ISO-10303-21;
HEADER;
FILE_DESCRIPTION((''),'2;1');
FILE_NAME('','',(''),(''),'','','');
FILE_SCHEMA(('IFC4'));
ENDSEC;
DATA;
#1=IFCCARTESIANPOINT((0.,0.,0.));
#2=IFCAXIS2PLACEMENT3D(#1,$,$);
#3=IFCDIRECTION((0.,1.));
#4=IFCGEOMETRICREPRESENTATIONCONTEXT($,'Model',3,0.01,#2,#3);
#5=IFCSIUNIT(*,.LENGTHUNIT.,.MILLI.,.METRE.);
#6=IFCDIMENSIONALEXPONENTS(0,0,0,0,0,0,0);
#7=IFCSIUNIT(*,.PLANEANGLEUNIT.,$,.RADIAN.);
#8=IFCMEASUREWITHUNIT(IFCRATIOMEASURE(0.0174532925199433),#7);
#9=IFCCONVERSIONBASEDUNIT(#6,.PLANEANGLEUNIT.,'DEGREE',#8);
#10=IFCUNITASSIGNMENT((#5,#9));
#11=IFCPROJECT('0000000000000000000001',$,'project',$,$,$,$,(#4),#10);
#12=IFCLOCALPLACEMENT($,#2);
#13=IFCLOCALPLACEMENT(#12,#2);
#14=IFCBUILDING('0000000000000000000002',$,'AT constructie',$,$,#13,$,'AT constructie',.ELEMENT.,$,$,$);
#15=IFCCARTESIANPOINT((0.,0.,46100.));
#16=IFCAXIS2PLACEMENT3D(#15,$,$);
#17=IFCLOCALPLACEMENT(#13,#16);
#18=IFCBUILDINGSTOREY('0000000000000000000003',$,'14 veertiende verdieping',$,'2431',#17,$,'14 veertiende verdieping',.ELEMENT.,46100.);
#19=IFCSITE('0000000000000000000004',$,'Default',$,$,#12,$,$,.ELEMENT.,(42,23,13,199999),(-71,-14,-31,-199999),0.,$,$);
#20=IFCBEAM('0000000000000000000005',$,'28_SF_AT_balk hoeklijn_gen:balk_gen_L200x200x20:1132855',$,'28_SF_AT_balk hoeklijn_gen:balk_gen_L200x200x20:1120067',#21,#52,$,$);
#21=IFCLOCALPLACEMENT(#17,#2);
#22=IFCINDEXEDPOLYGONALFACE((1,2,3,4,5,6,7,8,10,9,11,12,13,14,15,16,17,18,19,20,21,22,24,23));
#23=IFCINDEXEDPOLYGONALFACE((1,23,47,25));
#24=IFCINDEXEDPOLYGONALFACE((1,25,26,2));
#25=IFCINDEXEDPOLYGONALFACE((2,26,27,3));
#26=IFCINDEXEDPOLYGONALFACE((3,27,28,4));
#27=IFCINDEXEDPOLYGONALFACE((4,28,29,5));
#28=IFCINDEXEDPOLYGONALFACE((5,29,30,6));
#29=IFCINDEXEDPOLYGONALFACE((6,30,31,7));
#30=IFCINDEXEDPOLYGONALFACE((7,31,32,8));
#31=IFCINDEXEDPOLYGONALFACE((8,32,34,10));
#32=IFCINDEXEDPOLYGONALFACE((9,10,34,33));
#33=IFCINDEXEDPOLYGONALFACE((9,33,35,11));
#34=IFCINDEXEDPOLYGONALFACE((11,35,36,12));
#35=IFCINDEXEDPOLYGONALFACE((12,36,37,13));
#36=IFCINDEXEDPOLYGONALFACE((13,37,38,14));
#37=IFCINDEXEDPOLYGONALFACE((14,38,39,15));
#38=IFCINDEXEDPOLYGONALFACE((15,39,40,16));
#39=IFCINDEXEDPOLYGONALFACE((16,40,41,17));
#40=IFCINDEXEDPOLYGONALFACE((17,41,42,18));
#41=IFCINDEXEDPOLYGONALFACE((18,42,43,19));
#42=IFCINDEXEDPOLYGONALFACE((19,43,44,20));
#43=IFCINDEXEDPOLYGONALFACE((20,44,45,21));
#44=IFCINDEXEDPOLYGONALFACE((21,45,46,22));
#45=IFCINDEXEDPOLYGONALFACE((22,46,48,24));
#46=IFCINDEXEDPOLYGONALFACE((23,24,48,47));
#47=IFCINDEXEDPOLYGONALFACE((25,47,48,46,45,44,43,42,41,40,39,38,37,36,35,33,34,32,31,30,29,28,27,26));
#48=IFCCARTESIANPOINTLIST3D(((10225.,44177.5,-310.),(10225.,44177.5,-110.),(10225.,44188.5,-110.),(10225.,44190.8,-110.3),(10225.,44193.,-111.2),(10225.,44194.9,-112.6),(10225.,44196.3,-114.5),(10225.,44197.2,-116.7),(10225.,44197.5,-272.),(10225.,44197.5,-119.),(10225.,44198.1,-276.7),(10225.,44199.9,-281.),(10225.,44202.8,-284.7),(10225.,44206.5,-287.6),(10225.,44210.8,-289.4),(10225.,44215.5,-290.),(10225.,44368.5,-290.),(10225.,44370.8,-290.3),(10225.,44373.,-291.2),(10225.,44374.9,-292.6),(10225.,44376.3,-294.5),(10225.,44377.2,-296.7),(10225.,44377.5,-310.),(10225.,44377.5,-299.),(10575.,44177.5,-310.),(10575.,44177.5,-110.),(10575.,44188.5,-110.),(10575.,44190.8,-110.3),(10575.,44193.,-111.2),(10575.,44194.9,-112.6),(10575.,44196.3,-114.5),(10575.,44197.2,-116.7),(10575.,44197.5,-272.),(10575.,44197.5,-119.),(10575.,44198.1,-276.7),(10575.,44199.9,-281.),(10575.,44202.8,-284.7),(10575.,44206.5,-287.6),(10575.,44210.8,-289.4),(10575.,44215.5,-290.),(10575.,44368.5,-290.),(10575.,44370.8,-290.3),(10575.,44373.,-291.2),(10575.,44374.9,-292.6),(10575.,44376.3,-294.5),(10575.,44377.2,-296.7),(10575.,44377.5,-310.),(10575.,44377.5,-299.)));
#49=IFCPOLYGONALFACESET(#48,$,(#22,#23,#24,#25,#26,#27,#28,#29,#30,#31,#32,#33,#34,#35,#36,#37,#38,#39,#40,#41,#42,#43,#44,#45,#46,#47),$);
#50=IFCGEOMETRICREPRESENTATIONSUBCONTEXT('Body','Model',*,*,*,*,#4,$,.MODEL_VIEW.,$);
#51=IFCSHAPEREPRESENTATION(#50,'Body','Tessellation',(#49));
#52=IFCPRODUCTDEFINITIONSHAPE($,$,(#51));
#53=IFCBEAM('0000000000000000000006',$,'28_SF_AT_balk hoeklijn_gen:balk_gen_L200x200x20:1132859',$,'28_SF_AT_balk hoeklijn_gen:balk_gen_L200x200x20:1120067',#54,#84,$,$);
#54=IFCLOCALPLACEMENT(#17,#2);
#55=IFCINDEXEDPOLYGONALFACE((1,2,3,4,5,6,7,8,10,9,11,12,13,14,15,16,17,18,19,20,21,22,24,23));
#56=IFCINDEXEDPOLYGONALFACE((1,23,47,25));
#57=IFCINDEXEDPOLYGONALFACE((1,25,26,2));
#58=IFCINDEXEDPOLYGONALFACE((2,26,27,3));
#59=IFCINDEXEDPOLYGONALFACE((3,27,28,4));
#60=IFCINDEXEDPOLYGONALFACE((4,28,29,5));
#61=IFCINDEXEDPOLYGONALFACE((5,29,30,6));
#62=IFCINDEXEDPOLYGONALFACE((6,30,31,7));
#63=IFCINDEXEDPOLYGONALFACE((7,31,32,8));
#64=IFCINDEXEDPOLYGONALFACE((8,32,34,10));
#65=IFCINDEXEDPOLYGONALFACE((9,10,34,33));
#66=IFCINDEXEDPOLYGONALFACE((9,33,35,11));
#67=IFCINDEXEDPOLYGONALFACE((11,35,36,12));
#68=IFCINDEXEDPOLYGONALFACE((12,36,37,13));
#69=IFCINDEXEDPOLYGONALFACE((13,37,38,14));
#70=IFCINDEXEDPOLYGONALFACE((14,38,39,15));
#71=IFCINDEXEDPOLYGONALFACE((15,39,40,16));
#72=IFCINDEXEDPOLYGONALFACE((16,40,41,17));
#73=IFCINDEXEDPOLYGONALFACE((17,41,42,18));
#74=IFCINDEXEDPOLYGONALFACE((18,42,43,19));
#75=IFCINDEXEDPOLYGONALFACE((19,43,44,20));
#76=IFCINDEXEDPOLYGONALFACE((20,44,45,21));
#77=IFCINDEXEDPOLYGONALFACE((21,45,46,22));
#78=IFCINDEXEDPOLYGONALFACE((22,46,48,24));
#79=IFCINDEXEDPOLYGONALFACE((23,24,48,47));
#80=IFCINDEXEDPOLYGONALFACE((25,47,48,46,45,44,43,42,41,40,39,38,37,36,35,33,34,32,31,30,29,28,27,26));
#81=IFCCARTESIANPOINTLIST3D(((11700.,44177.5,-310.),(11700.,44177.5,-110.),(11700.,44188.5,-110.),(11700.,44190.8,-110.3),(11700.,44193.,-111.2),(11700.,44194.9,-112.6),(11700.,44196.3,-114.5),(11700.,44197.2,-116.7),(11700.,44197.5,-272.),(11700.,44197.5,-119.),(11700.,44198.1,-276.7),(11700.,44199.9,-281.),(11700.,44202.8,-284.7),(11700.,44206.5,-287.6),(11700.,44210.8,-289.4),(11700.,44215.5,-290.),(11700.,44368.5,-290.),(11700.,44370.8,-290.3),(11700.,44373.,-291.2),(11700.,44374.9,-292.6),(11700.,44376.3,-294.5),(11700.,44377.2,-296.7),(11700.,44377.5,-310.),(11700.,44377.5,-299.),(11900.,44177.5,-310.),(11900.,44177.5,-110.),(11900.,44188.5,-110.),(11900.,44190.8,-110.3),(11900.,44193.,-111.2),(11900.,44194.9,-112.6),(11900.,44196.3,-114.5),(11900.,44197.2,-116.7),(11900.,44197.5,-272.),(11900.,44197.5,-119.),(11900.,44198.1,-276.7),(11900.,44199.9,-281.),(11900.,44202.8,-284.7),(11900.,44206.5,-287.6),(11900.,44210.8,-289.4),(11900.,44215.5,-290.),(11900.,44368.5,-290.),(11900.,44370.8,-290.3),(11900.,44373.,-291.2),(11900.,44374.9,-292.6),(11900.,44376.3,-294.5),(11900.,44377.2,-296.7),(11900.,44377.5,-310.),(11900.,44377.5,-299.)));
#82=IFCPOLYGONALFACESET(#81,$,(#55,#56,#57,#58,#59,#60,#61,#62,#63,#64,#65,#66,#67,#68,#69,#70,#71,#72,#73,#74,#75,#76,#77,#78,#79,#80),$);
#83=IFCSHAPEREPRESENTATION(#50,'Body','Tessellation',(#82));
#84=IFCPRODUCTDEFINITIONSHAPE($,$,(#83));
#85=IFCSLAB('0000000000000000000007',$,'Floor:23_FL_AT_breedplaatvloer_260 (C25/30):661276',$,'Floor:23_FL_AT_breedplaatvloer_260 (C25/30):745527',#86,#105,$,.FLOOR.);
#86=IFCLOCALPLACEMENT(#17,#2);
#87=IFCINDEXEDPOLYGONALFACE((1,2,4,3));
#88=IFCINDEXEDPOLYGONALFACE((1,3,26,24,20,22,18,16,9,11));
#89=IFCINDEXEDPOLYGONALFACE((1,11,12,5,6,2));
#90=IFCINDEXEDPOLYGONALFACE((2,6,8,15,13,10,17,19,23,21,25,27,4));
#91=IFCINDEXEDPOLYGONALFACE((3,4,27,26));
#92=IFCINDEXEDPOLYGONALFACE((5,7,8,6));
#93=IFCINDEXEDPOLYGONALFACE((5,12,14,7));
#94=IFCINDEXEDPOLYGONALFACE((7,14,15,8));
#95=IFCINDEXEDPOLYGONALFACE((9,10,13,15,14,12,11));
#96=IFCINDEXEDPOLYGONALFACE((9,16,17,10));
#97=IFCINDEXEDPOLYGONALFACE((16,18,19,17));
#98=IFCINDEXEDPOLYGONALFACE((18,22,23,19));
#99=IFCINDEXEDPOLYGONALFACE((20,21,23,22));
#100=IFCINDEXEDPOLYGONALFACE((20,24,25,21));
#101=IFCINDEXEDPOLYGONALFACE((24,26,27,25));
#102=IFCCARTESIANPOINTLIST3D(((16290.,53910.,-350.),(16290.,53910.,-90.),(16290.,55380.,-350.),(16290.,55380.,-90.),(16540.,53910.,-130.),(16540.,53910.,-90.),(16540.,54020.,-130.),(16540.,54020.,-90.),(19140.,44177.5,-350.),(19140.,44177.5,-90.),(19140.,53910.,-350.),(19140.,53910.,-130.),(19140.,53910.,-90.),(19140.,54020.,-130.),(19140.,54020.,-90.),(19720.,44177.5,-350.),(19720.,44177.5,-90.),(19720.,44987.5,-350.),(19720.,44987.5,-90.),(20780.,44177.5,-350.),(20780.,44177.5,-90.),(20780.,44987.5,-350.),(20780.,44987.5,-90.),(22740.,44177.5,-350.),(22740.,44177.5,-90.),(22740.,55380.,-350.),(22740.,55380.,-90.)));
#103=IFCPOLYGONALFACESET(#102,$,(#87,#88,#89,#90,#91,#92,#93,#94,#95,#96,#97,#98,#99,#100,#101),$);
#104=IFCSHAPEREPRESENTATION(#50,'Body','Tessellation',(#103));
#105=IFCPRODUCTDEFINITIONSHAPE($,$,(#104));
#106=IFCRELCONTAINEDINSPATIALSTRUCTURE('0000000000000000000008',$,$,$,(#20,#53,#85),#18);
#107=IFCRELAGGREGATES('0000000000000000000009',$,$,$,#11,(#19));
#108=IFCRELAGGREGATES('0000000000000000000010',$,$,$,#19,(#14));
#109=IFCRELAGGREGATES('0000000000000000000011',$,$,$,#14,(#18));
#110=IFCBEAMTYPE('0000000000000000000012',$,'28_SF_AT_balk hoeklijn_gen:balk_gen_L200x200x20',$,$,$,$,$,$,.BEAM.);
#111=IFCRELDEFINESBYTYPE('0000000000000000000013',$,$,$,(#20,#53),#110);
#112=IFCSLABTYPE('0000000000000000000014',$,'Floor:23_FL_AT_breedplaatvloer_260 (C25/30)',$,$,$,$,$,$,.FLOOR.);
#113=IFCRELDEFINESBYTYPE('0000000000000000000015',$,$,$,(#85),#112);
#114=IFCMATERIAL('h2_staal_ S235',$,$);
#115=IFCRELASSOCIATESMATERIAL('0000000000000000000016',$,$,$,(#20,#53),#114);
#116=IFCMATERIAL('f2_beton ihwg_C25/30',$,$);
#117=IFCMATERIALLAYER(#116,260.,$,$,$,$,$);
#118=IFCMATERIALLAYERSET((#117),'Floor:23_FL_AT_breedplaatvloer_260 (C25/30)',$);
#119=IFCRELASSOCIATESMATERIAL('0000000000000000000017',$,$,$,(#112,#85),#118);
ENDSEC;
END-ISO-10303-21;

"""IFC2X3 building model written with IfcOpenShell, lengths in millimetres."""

from ifc_helpers import new_model, entity, si_unit, converted_unit, direction, frame, frame_2d, origin, origin_2d_with_axis, place, context, subcontext, project, spatial, polyline, circle_curve, parameter, trimmed, segment, composite_curve, rectangle, outline, extrude, material, layer, layer_set, layer_usage, type_object, element, save


model = new_model("IFC2X3")

# Units and contexts
model_context = context("Model", 3, precision=0.01, world=origin(), true_north=direction((0.0, 1.0)))
body_context = subcontext(model_context, "Body", "Model", "MODEL_VIEW")
ifc_project = project(units=[si_unit("LENGTHUNIT", "METRE", prefix="MILLI"), converted_unit("PLANEANGLEUNIT", "DEGREE", entity("IfcRatioMeasure", 0.0174532925199433), si_unit("PLANEANGLEUNIT", "RADIAN"), dimensions=[0, 0, 0, 0, 0, 0, 0])], contexts=[model_context])

# Site, building, storey
site_placement = place(None, origin())
site = spatial("IfcSite", under=ifc_project, at=site_placement, Name="Default", CompositionType="ELEMENT", RefLatitude=(42, 23, 13, 199999), RefLongitude=(-71, -14, -31, -199999), RefElevation=0.0)
building_placement = place(site_placement, origin())
building = spatial("IfcBuilding", under=site, at=building_placement, Name="AT constructie", LongName="AT constructie", CompositionType="ELEMENT")
storey_placement = place(building_placement, frame((0.0, 0.0, 46100.0)))
storey = spatial("IfcBuildingStorey", under=building, at=storey_placement, Name="14 veertiende verdieping", ObjectType="2431", LongName="14 veertiende verdieping", CompositionType="ELEMENT", Elevation=46100.0)

# Beams
ifc_material_1 = material(Name="h2_staal_ S235")
beam_type = type_object("IfcBeamType", Name="28_SF_AT_balk hoeklijn_gen:balk_gen_L200x200x20", PredefinedType="BEAM")
beam_1_placement = place(storey_placement, frame((10225.0, 44177.5, -70.0)))
element("IfcBeam", 1, at=beam_1_placement, inside=storey, type_object=beam_type, material=ifc_material_1, Name="28_SF_AT_balk hoeklijn_gen:balk_gen_L200x200x20:1132855", ObjectType="28_SF_AT_balk hoeklijn_gen:balk_gen_L200x200x20:1120067", context=body_context, shape_type="SweptSolid", body=[
    extrude(outline(composite_curve([segment(polyline([(-124.4, -75.6), (75.6, -75.6)]), True, "CONTINUOUS"), segment(polyline([(75.6, -75.6), (75.6, 124.4)]), True, "CONTINUOUS"), segment(polyline([(75.6, 124.4), (64.6, 124.4)]), True, "CONTINUOUS"), segment(trimmed(circle_curve(frame_2d((64.6, 115.4), x_axis=(0.0, 1.0)), 9.0), [parameter(0.0)], [parameter(90.0)], True, "PARAMETER"), True, "CONTINUOUS"), segment(polyline([(55.6, 115.4), (55.6, -37.6)]), True, "CONTINUOUS"), segment(trimmed(circle_curve(frame_2d((37.6, -37.6), x_axis=(1.0, 0.0)), 18.0), [parameter(270.0)], [parameter(0.0)], True, "PARAMETER"), False, "CONTINUOUS"), segment(polyline([(37.6, -55.6), (-115.4, -55.6)]), True, "CONTINUOUS"), segment(trimmed(circle_curve(frame_2d((-115.4, -64.6), x_axis=(0.0, 1.0)), 9.0), [parameter(0.0)], [parameter(90.0)], True, "PARAMETER"), True, "CONTINUOUS"), segment(polyline([(-124.4, -64.6), (-124.4, -75.6)]), True, "CONTINUOUS")], self_intersect=False)), frame((0.0, 75.6, -164.4), z_axis=(1.0, 0.0, 0.0), x_axis=(0.0, 0.0, -1.0)), (0.0, 0.0, 1.0), 350.0),
])
beam_2_placement = place(storey_placement, frame((11700.0, 44177.5, -70.0)))
element("IfcBeam", 2, at=beam_2_placement, inside=storey, type_object=beam_type, material=ifc_material_1, Name="28_SF_AT_balk hoeklijn_gen:balk_gen_L200x200x20:1132859", ObjectType="28_SF_AT_balk hoeklijn_gen:balk_gen_L200x200x20:1120067", context=body_context, shape_type="SweptSolid", body=[
    extrude(outline(composite_curve([segment(polyline([(-124.4, -75.6), (75.6, -75.6)]), True, "CONTINUOUS"), segment(polyline([(75.6, -75.6), (75.6, 124.4)]), True, "CONTINUOUS"), segment(polyline([(75.6, 124.4), (64.6, 124.4)]), True, "CONTINUOUS"), segment(trimmed(circle_curve(frame_2d((64.6, 115.4), x_axis=(0.0, 1.0)), 9.0), [parameter(0.0)], [parameter(90.0)], True, "PARAMETER"), True, "CONTINUOUS"), segment(polyline([(55.6, 115.4), (55.6, -37.6)]), True, "CONTINUOUS"), segment(trimmed(circle_curve(frame_2d((37.6, -37.6), x_axis=(1.0, 0.0)), 18.0), [parameter(270.0)], [parameter(0.0)], True, "PARAMETER"), False, "CONTINUOUS"), segment(polyline([(37.6, -55.6), (-115.4, -55.6)]), True, "CONTINUOUS"), segment(trimmed(circle_curve(frame_2d((-115.4, -64.6), x_axis=(0.0, 1.0)), 9.0), [parameter(0.0)], [parameter(90.0)], True, "PARAMETER"), True, "CONTINUOUS"), segment(polyline([(-124.4, -64.6), (-124.4, -75.6)]), True, "CONTINUOUS")], self_intersect=False)), frame((0.0, 75.6, -164.4), z_axis=(1.0, 0.0, 0.0), x_axis=(0.0, 0.0, -1.0)), (0.0, 0.0, 1.0), 200.0),
])

# Slab, openings
ifc_material_2 = material(Name="f2_beton ihwg_C25/30")
ifc_layer_1 = layer(ifc_material_2, 260.0)
ifc_layer_set_1 = layer_set([ifc_layer_1], Name="Floor:23_FL_AT_breedplaatvloer_260 (C25/30)")
ifc_layer_usage_1 = layer_usage(ifc_layer_set_1, "AXIS3", "POSITIVE", 0.0)
slab_type = type_object("IfcSlabType", Name="Floor:23_FL_AT_breedplaatvloer_260 (C25/30)", PredefinedType="FLOOR", material=ifc_layer_set_1)
slab_placement = place(storey_placement, frame((16290.0, 44177.5, -350.0)))
slab = element("IfcSlab", 3, at=slab_placement, inside=storey, type_object=slab_type, material=ifc_layer_usage_1, Name="Floor:23_FL_AT_breedplaatvloer_260 (C25/30):661276", ObjectType="Floor:23_FL_AT_breedplaatvloer_260 (C25/30):745527", PredefinedType="FLOOR", context=body_context, shape_type="SweptSolid", body=[
    extrude(outline(polyline([(3225.0, 4131.2), (3225.0, 5601.2), (-3225.0, 5601.2), (-3225.0, -5601.2), (375.0, -5601.2), (375.0, 4131.2), (3225.0, 4131.2)])), frame((3225.0, 5601.2, 260.0), z_axis=(0.0, 0.0, -1.0), x_axis=(-1.0, 0.0, 0.0)), (0.0, 0.0, 1.0), 260.0),
])
opening_1_placement = place(storey_placement, frame((16290.0, 44177.5, -350.0)))
element("IfcOpeningElement", 4, at=opening_1_placement, cuts=slab, ObjectType="Opening", context=body_context, shape_type="SweptSolid", body=[
    extrude(rectangle(XDim=3555.0, YDim=1060.0, at=frame_2d((-735.0, -6568.8), x_axis=(0.0, 1.0))), frame((3225.0, 5601.2, 260.0), z_axis=(0.0, 0.0, -1.0), x_axis=(-1.0, 0.0, 0.0)), (0.0, 0.0, 1.0), 260.0),
])
opening_2_placement = place(slab_placement, origin())
element("IfcOpeningElement", 5, at=opening_2_placement, cuts=slab, ObjectType="Opening", context=body_context, shape_type="SweptSolid", body=[
    extrude(rectangle(XDim=2600.0, YDim=110.0, at=origin_2d_with_axis()), frame((1550.0, 9787.5, 220.0), z_axis=(0.0, 0.0, 1.0), x_axis=(-1.0, 0.0, 0.0)), (0.0, 0.0, 1.0), 40.0),
])

save(model, "model.ifc")
